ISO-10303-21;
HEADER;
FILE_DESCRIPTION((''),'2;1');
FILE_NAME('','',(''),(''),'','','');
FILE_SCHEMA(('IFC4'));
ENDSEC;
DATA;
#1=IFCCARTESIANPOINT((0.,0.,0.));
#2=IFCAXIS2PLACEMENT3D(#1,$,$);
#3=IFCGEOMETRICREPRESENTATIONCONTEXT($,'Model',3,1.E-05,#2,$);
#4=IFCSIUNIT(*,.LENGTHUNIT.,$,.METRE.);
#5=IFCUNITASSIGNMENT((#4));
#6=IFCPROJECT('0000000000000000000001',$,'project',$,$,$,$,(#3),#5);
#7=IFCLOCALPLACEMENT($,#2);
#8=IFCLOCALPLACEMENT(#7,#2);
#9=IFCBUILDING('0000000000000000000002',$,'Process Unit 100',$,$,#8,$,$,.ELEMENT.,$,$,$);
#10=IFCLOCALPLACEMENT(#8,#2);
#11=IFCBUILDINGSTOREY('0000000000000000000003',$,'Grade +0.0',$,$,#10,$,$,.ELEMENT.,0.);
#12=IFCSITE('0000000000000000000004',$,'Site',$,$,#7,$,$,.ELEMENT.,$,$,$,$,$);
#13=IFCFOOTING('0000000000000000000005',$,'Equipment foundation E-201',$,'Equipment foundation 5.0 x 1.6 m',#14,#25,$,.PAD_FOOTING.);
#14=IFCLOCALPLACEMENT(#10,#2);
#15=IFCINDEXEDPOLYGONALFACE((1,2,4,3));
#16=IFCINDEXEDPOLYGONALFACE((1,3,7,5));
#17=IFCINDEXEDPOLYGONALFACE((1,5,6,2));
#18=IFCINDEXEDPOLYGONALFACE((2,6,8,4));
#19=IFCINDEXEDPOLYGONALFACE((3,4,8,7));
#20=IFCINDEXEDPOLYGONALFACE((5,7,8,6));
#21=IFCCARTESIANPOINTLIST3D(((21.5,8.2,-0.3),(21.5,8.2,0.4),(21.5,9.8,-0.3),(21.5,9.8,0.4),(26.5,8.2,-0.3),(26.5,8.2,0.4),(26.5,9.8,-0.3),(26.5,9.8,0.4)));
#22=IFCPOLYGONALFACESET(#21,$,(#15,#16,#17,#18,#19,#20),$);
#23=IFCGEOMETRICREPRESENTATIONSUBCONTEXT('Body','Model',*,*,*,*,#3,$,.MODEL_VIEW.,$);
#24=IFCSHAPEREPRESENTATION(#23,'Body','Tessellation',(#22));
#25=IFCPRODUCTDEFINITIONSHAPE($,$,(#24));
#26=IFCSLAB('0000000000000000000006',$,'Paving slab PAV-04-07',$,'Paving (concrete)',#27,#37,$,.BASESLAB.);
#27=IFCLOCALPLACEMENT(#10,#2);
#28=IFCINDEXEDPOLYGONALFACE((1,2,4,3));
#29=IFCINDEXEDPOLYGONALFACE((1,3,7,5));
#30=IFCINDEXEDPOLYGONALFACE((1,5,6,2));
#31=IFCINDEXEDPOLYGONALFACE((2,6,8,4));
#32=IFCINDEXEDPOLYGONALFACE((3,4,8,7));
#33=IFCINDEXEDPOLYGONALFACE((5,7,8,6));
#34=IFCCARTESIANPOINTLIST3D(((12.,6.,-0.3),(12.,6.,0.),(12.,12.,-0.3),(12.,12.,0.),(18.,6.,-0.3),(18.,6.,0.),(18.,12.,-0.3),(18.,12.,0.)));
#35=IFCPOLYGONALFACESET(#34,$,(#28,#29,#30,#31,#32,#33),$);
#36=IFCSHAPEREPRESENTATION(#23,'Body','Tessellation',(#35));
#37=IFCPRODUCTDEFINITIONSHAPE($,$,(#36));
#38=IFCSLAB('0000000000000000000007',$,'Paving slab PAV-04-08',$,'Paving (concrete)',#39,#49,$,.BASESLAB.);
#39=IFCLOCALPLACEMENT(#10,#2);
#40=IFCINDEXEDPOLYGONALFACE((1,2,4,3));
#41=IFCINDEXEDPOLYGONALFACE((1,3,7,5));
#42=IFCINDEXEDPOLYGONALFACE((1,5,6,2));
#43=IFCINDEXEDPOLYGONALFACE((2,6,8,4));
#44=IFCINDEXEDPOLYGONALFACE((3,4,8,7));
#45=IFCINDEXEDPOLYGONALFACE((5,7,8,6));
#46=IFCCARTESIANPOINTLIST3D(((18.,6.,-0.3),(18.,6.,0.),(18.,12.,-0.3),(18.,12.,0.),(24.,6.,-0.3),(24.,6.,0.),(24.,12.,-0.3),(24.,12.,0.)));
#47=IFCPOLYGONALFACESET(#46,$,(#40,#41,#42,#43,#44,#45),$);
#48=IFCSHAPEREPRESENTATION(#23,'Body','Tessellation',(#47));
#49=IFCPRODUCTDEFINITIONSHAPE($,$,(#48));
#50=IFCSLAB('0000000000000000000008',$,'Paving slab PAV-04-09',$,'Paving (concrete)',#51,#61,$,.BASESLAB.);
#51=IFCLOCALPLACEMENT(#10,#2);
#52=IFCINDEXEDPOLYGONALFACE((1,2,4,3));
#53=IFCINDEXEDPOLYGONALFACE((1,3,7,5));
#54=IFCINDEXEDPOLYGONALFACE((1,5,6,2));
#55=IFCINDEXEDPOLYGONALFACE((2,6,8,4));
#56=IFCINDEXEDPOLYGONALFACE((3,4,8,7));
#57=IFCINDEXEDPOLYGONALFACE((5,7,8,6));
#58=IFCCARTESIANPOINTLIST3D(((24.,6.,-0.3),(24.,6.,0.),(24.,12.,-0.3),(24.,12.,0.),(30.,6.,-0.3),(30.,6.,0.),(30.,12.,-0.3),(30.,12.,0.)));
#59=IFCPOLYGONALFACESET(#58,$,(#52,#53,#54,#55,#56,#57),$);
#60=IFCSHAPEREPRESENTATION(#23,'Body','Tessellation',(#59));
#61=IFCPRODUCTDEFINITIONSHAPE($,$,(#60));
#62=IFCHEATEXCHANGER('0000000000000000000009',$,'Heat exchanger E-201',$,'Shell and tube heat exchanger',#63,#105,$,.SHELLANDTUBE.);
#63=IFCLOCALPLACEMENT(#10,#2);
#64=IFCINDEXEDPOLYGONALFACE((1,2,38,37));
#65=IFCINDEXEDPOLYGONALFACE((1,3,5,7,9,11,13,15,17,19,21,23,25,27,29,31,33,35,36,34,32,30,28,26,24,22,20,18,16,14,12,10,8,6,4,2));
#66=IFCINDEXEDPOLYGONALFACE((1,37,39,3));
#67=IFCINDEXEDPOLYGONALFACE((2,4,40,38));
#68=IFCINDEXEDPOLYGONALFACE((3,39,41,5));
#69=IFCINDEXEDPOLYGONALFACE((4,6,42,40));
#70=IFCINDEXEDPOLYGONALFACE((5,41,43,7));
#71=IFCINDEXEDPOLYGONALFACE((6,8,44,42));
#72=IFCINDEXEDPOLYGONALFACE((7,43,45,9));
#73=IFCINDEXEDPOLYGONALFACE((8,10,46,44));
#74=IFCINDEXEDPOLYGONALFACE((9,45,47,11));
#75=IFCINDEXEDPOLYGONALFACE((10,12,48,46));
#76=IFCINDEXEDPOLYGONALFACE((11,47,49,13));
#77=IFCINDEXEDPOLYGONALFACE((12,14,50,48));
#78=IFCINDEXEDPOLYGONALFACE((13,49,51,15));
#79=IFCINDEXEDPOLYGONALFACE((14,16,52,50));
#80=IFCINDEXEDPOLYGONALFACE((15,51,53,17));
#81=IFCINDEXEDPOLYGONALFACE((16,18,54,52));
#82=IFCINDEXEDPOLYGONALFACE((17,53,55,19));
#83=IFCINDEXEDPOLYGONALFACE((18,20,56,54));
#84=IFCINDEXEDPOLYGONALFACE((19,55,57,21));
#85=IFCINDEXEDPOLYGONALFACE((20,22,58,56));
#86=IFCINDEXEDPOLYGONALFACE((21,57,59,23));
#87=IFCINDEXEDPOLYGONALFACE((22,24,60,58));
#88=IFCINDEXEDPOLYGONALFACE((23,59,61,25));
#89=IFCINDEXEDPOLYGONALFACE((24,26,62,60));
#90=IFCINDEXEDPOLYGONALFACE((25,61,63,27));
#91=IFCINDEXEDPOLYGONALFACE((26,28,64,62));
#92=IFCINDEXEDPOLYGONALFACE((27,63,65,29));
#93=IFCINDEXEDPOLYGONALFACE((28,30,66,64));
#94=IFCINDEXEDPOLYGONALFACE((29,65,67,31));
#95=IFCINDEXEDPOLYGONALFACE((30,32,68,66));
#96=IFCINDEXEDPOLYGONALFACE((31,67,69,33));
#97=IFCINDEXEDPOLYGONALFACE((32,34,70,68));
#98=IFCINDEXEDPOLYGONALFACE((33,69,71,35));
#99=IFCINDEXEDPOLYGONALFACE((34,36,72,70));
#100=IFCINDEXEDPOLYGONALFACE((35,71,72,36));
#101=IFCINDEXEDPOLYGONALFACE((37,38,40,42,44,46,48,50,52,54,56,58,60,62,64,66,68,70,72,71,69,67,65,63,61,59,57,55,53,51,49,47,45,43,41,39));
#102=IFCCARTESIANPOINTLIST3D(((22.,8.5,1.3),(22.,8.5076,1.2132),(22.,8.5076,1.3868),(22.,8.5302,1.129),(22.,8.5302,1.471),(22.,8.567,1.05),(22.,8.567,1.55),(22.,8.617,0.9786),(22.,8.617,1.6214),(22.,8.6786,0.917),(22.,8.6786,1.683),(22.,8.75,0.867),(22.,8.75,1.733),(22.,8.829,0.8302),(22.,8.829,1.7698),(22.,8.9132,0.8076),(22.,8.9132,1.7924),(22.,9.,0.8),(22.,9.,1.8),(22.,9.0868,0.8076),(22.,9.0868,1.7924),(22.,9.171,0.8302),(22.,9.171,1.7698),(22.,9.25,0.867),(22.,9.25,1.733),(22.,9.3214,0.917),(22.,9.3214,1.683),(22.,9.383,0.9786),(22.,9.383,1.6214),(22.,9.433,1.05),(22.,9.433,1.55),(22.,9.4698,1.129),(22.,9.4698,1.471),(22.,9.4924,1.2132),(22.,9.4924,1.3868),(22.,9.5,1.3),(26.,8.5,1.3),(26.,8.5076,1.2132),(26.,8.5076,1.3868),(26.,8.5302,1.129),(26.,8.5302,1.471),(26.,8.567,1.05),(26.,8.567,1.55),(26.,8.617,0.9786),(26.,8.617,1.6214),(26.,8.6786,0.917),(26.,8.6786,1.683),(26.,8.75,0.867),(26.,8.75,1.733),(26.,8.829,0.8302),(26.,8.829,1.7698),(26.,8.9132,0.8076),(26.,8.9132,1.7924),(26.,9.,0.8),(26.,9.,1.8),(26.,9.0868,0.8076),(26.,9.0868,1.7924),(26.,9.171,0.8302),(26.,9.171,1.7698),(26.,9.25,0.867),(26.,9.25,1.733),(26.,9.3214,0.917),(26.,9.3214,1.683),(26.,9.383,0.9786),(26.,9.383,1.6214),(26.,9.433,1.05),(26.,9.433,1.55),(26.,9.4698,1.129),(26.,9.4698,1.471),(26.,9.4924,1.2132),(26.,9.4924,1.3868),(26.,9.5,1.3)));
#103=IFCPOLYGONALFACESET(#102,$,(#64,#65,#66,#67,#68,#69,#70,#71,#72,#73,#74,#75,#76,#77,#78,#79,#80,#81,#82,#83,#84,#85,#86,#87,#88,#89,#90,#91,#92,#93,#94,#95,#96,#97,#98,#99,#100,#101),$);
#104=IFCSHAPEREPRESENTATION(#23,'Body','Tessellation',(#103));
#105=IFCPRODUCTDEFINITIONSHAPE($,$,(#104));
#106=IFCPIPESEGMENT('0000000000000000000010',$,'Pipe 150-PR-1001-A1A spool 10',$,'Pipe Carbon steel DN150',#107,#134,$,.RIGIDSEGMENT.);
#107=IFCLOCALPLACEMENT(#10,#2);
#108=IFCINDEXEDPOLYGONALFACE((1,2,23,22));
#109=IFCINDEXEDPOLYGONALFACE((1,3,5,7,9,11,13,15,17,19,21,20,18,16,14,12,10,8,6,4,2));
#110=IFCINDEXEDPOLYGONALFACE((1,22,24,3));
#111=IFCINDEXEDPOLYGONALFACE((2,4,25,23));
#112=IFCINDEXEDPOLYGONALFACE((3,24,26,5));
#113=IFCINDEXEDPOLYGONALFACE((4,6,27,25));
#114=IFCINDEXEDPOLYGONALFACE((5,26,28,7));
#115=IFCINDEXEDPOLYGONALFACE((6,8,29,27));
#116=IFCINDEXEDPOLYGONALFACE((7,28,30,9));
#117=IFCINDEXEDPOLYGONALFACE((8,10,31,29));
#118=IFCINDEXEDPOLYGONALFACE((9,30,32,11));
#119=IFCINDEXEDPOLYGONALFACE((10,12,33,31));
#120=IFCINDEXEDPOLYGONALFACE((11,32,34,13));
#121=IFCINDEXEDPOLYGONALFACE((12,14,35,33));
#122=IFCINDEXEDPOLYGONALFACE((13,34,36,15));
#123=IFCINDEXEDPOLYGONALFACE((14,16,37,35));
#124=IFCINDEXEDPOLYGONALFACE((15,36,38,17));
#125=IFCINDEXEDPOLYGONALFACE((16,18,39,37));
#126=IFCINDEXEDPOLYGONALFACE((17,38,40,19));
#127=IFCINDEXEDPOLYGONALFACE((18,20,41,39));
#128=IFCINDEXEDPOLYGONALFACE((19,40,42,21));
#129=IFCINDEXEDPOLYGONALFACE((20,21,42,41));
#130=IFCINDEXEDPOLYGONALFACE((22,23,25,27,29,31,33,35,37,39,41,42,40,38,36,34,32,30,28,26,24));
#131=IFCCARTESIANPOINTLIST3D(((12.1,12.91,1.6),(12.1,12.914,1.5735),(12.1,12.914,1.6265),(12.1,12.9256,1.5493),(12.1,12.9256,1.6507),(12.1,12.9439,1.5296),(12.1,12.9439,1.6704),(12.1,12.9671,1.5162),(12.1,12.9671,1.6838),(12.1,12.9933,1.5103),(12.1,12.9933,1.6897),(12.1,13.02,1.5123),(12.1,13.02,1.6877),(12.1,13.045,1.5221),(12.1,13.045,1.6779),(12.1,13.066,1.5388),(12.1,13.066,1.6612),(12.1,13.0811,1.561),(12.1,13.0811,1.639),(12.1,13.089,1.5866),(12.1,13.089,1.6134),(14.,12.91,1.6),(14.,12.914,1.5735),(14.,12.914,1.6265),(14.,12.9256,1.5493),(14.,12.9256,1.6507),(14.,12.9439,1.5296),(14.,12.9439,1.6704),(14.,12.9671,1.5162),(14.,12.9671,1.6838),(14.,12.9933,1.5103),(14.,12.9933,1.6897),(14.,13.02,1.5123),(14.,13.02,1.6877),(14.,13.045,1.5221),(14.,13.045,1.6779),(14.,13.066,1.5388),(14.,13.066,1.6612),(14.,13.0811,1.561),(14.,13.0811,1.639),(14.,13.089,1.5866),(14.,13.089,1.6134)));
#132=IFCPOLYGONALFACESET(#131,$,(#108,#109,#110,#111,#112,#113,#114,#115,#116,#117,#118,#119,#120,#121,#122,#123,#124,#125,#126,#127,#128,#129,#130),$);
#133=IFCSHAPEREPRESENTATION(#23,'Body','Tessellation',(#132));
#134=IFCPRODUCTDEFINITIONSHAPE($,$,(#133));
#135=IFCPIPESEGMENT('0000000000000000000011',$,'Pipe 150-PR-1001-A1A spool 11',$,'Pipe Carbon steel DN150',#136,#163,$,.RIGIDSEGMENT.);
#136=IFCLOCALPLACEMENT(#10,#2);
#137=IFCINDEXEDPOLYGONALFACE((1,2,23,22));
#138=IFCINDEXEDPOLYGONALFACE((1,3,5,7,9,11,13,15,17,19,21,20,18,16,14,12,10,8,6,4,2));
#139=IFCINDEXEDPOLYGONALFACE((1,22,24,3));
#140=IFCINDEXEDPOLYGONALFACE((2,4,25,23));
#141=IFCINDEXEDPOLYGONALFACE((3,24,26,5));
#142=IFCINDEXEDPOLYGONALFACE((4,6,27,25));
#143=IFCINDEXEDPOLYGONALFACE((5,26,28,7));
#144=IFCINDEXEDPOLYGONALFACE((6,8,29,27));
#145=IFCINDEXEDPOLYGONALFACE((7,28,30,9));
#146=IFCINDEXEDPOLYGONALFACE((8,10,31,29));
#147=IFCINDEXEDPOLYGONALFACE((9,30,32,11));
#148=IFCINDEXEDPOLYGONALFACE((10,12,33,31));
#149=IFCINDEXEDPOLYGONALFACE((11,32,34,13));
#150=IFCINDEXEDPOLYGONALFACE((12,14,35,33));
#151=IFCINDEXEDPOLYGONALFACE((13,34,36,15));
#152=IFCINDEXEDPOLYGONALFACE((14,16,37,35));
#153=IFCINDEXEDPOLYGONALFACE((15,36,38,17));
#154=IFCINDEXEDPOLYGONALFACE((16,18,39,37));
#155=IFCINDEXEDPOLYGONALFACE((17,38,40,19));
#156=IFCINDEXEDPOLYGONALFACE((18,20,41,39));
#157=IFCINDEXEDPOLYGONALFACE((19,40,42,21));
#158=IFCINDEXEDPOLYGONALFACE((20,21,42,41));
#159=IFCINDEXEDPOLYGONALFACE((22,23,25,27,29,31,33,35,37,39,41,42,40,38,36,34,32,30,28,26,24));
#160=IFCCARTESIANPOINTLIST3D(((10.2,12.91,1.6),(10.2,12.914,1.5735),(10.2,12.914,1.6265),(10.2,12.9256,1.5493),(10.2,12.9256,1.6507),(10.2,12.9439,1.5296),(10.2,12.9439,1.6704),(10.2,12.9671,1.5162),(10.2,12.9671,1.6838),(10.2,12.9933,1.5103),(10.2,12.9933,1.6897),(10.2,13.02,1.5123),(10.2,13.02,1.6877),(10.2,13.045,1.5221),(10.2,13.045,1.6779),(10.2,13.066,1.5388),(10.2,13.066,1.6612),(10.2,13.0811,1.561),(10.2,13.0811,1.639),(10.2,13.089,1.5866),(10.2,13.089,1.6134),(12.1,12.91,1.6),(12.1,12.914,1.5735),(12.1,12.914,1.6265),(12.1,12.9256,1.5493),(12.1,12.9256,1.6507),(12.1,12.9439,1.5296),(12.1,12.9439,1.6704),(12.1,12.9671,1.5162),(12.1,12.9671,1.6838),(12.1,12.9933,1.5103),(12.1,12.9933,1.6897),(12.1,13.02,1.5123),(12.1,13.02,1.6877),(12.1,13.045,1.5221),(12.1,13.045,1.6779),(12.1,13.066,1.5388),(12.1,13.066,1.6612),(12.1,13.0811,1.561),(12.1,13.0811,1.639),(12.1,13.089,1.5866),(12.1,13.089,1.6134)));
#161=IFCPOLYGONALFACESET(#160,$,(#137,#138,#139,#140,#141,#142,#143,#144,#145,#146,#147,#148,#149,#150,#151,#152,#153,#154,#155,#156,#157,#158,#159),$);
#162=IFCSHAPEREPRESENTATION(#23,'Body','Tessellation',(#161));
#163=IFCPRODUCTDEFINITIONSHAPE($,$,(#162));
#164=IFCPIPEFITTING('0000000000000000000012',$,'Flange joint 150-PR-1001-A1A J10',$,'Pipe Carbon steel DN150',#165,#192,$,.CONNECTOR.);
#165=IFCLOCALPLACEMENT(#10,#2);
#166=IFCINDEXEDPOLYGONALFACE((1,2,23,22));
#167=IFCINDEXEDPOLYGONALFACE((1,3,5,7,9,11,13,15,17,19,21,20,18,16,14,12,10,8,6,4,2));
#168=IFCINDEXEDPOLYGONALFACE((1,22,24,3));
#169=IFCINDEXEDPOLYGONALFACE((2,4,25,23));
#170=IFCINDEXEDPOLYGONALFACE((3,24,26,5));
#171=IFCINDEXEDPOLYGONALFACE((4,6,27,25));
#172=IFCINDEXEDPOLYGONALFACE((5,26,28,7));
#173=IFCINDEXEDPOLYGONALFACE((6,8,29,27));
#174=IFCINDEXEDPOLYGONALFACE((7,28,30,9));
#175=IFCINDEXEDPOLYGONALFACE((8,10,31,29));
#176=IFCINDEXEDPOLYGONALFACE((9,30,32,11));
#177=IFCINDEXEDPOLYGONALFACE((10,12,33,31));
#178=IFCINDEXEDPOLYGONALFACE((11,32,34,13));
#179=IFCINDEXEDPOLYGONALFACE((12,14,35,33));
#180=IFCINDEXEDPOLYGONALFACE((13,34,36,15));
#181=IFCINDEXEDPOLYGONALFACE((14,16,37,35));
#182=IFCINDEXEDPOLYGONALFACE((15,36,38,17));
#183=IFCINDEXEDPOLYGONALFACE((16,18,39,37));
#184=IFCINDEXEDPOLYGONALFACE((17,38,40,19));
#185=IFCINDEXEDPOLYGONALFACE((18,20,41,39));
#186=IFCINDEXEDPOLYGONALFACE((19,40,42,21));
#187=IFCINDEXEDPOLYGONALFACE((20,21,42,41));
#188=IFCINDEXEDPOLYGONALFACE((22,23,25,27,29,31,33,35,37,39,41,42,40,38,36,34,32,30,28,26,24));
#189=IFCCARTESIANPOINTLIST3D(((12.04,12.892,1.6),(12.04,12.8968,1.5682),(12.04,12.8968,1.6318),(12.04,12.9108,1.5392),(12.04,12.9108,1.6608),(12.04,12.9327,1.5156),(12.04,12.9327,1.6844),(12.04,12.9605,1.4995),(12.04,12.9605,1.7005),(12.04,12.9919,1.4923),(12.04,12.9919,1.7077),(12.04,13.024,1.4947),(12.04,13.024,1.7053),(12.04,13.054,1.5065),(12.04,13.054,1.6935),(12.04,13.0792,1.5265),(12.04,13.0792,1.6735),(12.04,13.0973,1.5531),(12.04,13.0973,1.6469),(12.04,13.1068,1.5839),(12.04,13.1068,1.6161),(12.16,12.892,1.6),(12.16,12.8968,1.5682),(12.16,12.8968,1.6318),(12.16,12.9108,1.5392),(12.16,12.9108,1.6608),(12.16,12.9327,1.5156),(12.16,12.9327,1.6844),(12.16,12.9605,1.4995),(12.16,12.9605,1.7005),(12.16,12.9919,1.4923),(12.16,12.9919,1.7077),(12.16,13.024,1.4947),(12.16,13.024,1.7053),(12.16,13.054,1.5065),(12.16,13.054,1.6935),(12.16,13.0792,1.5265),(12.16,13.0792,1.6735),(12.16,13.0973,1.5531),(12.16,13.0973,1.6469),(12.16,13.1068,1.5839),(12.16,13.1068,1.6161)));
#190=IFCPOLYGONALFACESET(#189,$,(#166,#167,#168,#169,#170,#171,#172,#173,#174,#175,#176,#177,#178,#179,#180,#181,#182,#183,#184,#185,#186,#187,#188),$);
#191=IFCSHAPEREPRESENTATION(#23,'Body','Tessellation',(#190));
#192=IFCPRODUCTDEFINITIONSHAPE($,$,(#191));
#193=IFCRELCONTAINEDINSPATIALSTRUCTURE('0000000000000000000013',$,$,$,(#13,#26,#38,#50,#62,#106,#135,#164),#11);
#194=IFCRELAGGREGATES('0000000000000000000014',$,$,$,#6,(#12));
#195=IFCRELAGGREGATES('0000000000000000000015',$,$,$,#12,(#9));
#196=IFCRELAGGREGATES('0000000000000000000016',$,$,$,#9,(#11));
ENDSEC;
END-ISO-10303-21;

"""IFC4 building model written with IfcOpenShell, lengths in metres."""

from ifc_helpers import new_model, si_unit, frame, origin, place, context, subcontext, project, spatial, rectangle, circle, extrude, element, save


model = new_model("IFC4")

# Units and contexts
model_context = context("Model", 3, precision=1e-05, world=origin())
body_context = subcontext(model_context, "Body", "Model", "MODEL_VIEW")
ifc_project = project(units=[si_unit("LENGTHUNIT", "METRE")], contexts=[model_context])

# Site, building, storey
site_placement = place(None, origin())
site = spatial("IfcSite", under=ifc_project, at=site_placement, Name="Site", CompositionType="ELEMENT")
building_placement = place(site_placement, origin())
building = spatial("IfcBuilding", under=site, at=building_placement, Name="Process Unit 100", CompositionType="ELEMENT")
storey_placement = place(building_placement, origin())
storey = spatial("IfcBuildingStorey", under=building, at=storey_placement, Name="Grade +0.0", CompositionType="ELEMENT", Elevation=0.0)

# Footing
footing_placement = place(storey_placement, frame((24.0, 9.0, -0.3), z_axis=(0.0, 0.0, 1.0), x_axis=(1.0, 0.0, 0.0)))
element("IfcFooting", 1, at=footing_placement, inside=storey, Name="Equipment foundation E-201", ObjectType="Equipment foundation 5.0 x 1.6 m", PredefinedType="PAD_FOOTING", context=body_context, shape_type="SweptSolid", body=[
    extrude(rectangle(XDim=5.0, YDim=1.6), origin(), (0.0, 0.0, 1.0), 0.7),
])

# Slabs
for number, where, z_axis, x_axis, name in (
    (2, (15.0, 9.0, -0.3), (0.0, 0.0, 1.0), (1.0, 0.0, 0.0), "Paving slab PAV-04-07"),
    (3, (21.0, 9.0, -0.3), (0.0, 0.0, 1.0), (1.0, 0.0, 0.0), "Paving slab PAV-04-08"),
    (4, (27.0, 9.0, -0.3), (0.0, 0.0, 1.0), (1.0, 0.0, 0.0), "Paving slab PAV-04-09"),
):
    element("IfcSlab", number, at=place(storey_placement, frame(where, z_axis=z_axis, x_axis=x_axis)), inside=storey, Name=name, ObjectType="Paving (concrete)", PredefinedType="BASESLAB", context=body_context, shape_type="SweptSolid", body=[
        extrude(rectangle(XDim=6.0, YDim=6.0), origin(), (0.0, 0.0, 1.0), 0.3),
    ])

# Heat exchanger
heat_exchanger_placement = place(storey_placement, frame((22.0, 9.0, 1.3), z_axis=(1.0, 0.0, 0.0), x_axis=(0.0, 1.0, 0.0)))
element("IfcHeatExchanger", 5, at=heat_exchanger_placement, inside=storey, Name="Heat exchanger E-201", ObjectType="Shell and tube heat exchanger", PredefinedType="SHELLANDTUBE", context=body_context, shape_type="SweptSolid", body=[
    extrude(circle(Radius=0.5), origin(), (0.0, 0.0, 1.0), 4.0),
])

# Pipe segments
for number, where, z_axis, x_axis, name in (
    (6, (14.0, 13.0, 1.6), (-1.0, 0.0, 0.0), (0.0, -1.0, 0.0), "Pipe 150-PR-1001-A1A spool 10"),
    (7, (12.1, 13.0, 1.6), (-1.0, 0.0, 0.0), (0.0, -1.0, 0.0), "Pipe 150-PR-1001-A1A spool 11"),
):
    element("IfcPipeSegment", number, at=place(storey_placement, frame(where, z_axis=z_axis, x_axis=x_axis)), inside=storey, Name=name, ObjectType="Pipe Carbon steel DN150", PredefinedType="RIGIDSEGMENT", context=body_context, shape_type="SweptSolid", body=[
        extrude(circle(Radius=0.09), origin(), (0.0, 0.0, 1.0), 1.9),
    ])

# Pipe fitting
pipe_fitting_1_placement = place(storey_placement, frame((12.16, 13.0, 1.6), z_axis=(-1.0, 0.0, 0.0), x_axis=(0.0, -1.0, 0.0)))
element("IfcPipeFitting", 8, at=pipe_fitting_1_placement, inside=storey, Name="Flange joint 150-PR-1001-A1A J10", ObjectType="Pipe Carbon steel DN150", PredefinedType="CONNECTOR", context=body_context, shape_type="SweptSolid", body=[
    extrude(circle(Radius=0.108), origin(), (0.0, 0.0, 1.0), 0.12),
])

save(model, "model.ifc")
